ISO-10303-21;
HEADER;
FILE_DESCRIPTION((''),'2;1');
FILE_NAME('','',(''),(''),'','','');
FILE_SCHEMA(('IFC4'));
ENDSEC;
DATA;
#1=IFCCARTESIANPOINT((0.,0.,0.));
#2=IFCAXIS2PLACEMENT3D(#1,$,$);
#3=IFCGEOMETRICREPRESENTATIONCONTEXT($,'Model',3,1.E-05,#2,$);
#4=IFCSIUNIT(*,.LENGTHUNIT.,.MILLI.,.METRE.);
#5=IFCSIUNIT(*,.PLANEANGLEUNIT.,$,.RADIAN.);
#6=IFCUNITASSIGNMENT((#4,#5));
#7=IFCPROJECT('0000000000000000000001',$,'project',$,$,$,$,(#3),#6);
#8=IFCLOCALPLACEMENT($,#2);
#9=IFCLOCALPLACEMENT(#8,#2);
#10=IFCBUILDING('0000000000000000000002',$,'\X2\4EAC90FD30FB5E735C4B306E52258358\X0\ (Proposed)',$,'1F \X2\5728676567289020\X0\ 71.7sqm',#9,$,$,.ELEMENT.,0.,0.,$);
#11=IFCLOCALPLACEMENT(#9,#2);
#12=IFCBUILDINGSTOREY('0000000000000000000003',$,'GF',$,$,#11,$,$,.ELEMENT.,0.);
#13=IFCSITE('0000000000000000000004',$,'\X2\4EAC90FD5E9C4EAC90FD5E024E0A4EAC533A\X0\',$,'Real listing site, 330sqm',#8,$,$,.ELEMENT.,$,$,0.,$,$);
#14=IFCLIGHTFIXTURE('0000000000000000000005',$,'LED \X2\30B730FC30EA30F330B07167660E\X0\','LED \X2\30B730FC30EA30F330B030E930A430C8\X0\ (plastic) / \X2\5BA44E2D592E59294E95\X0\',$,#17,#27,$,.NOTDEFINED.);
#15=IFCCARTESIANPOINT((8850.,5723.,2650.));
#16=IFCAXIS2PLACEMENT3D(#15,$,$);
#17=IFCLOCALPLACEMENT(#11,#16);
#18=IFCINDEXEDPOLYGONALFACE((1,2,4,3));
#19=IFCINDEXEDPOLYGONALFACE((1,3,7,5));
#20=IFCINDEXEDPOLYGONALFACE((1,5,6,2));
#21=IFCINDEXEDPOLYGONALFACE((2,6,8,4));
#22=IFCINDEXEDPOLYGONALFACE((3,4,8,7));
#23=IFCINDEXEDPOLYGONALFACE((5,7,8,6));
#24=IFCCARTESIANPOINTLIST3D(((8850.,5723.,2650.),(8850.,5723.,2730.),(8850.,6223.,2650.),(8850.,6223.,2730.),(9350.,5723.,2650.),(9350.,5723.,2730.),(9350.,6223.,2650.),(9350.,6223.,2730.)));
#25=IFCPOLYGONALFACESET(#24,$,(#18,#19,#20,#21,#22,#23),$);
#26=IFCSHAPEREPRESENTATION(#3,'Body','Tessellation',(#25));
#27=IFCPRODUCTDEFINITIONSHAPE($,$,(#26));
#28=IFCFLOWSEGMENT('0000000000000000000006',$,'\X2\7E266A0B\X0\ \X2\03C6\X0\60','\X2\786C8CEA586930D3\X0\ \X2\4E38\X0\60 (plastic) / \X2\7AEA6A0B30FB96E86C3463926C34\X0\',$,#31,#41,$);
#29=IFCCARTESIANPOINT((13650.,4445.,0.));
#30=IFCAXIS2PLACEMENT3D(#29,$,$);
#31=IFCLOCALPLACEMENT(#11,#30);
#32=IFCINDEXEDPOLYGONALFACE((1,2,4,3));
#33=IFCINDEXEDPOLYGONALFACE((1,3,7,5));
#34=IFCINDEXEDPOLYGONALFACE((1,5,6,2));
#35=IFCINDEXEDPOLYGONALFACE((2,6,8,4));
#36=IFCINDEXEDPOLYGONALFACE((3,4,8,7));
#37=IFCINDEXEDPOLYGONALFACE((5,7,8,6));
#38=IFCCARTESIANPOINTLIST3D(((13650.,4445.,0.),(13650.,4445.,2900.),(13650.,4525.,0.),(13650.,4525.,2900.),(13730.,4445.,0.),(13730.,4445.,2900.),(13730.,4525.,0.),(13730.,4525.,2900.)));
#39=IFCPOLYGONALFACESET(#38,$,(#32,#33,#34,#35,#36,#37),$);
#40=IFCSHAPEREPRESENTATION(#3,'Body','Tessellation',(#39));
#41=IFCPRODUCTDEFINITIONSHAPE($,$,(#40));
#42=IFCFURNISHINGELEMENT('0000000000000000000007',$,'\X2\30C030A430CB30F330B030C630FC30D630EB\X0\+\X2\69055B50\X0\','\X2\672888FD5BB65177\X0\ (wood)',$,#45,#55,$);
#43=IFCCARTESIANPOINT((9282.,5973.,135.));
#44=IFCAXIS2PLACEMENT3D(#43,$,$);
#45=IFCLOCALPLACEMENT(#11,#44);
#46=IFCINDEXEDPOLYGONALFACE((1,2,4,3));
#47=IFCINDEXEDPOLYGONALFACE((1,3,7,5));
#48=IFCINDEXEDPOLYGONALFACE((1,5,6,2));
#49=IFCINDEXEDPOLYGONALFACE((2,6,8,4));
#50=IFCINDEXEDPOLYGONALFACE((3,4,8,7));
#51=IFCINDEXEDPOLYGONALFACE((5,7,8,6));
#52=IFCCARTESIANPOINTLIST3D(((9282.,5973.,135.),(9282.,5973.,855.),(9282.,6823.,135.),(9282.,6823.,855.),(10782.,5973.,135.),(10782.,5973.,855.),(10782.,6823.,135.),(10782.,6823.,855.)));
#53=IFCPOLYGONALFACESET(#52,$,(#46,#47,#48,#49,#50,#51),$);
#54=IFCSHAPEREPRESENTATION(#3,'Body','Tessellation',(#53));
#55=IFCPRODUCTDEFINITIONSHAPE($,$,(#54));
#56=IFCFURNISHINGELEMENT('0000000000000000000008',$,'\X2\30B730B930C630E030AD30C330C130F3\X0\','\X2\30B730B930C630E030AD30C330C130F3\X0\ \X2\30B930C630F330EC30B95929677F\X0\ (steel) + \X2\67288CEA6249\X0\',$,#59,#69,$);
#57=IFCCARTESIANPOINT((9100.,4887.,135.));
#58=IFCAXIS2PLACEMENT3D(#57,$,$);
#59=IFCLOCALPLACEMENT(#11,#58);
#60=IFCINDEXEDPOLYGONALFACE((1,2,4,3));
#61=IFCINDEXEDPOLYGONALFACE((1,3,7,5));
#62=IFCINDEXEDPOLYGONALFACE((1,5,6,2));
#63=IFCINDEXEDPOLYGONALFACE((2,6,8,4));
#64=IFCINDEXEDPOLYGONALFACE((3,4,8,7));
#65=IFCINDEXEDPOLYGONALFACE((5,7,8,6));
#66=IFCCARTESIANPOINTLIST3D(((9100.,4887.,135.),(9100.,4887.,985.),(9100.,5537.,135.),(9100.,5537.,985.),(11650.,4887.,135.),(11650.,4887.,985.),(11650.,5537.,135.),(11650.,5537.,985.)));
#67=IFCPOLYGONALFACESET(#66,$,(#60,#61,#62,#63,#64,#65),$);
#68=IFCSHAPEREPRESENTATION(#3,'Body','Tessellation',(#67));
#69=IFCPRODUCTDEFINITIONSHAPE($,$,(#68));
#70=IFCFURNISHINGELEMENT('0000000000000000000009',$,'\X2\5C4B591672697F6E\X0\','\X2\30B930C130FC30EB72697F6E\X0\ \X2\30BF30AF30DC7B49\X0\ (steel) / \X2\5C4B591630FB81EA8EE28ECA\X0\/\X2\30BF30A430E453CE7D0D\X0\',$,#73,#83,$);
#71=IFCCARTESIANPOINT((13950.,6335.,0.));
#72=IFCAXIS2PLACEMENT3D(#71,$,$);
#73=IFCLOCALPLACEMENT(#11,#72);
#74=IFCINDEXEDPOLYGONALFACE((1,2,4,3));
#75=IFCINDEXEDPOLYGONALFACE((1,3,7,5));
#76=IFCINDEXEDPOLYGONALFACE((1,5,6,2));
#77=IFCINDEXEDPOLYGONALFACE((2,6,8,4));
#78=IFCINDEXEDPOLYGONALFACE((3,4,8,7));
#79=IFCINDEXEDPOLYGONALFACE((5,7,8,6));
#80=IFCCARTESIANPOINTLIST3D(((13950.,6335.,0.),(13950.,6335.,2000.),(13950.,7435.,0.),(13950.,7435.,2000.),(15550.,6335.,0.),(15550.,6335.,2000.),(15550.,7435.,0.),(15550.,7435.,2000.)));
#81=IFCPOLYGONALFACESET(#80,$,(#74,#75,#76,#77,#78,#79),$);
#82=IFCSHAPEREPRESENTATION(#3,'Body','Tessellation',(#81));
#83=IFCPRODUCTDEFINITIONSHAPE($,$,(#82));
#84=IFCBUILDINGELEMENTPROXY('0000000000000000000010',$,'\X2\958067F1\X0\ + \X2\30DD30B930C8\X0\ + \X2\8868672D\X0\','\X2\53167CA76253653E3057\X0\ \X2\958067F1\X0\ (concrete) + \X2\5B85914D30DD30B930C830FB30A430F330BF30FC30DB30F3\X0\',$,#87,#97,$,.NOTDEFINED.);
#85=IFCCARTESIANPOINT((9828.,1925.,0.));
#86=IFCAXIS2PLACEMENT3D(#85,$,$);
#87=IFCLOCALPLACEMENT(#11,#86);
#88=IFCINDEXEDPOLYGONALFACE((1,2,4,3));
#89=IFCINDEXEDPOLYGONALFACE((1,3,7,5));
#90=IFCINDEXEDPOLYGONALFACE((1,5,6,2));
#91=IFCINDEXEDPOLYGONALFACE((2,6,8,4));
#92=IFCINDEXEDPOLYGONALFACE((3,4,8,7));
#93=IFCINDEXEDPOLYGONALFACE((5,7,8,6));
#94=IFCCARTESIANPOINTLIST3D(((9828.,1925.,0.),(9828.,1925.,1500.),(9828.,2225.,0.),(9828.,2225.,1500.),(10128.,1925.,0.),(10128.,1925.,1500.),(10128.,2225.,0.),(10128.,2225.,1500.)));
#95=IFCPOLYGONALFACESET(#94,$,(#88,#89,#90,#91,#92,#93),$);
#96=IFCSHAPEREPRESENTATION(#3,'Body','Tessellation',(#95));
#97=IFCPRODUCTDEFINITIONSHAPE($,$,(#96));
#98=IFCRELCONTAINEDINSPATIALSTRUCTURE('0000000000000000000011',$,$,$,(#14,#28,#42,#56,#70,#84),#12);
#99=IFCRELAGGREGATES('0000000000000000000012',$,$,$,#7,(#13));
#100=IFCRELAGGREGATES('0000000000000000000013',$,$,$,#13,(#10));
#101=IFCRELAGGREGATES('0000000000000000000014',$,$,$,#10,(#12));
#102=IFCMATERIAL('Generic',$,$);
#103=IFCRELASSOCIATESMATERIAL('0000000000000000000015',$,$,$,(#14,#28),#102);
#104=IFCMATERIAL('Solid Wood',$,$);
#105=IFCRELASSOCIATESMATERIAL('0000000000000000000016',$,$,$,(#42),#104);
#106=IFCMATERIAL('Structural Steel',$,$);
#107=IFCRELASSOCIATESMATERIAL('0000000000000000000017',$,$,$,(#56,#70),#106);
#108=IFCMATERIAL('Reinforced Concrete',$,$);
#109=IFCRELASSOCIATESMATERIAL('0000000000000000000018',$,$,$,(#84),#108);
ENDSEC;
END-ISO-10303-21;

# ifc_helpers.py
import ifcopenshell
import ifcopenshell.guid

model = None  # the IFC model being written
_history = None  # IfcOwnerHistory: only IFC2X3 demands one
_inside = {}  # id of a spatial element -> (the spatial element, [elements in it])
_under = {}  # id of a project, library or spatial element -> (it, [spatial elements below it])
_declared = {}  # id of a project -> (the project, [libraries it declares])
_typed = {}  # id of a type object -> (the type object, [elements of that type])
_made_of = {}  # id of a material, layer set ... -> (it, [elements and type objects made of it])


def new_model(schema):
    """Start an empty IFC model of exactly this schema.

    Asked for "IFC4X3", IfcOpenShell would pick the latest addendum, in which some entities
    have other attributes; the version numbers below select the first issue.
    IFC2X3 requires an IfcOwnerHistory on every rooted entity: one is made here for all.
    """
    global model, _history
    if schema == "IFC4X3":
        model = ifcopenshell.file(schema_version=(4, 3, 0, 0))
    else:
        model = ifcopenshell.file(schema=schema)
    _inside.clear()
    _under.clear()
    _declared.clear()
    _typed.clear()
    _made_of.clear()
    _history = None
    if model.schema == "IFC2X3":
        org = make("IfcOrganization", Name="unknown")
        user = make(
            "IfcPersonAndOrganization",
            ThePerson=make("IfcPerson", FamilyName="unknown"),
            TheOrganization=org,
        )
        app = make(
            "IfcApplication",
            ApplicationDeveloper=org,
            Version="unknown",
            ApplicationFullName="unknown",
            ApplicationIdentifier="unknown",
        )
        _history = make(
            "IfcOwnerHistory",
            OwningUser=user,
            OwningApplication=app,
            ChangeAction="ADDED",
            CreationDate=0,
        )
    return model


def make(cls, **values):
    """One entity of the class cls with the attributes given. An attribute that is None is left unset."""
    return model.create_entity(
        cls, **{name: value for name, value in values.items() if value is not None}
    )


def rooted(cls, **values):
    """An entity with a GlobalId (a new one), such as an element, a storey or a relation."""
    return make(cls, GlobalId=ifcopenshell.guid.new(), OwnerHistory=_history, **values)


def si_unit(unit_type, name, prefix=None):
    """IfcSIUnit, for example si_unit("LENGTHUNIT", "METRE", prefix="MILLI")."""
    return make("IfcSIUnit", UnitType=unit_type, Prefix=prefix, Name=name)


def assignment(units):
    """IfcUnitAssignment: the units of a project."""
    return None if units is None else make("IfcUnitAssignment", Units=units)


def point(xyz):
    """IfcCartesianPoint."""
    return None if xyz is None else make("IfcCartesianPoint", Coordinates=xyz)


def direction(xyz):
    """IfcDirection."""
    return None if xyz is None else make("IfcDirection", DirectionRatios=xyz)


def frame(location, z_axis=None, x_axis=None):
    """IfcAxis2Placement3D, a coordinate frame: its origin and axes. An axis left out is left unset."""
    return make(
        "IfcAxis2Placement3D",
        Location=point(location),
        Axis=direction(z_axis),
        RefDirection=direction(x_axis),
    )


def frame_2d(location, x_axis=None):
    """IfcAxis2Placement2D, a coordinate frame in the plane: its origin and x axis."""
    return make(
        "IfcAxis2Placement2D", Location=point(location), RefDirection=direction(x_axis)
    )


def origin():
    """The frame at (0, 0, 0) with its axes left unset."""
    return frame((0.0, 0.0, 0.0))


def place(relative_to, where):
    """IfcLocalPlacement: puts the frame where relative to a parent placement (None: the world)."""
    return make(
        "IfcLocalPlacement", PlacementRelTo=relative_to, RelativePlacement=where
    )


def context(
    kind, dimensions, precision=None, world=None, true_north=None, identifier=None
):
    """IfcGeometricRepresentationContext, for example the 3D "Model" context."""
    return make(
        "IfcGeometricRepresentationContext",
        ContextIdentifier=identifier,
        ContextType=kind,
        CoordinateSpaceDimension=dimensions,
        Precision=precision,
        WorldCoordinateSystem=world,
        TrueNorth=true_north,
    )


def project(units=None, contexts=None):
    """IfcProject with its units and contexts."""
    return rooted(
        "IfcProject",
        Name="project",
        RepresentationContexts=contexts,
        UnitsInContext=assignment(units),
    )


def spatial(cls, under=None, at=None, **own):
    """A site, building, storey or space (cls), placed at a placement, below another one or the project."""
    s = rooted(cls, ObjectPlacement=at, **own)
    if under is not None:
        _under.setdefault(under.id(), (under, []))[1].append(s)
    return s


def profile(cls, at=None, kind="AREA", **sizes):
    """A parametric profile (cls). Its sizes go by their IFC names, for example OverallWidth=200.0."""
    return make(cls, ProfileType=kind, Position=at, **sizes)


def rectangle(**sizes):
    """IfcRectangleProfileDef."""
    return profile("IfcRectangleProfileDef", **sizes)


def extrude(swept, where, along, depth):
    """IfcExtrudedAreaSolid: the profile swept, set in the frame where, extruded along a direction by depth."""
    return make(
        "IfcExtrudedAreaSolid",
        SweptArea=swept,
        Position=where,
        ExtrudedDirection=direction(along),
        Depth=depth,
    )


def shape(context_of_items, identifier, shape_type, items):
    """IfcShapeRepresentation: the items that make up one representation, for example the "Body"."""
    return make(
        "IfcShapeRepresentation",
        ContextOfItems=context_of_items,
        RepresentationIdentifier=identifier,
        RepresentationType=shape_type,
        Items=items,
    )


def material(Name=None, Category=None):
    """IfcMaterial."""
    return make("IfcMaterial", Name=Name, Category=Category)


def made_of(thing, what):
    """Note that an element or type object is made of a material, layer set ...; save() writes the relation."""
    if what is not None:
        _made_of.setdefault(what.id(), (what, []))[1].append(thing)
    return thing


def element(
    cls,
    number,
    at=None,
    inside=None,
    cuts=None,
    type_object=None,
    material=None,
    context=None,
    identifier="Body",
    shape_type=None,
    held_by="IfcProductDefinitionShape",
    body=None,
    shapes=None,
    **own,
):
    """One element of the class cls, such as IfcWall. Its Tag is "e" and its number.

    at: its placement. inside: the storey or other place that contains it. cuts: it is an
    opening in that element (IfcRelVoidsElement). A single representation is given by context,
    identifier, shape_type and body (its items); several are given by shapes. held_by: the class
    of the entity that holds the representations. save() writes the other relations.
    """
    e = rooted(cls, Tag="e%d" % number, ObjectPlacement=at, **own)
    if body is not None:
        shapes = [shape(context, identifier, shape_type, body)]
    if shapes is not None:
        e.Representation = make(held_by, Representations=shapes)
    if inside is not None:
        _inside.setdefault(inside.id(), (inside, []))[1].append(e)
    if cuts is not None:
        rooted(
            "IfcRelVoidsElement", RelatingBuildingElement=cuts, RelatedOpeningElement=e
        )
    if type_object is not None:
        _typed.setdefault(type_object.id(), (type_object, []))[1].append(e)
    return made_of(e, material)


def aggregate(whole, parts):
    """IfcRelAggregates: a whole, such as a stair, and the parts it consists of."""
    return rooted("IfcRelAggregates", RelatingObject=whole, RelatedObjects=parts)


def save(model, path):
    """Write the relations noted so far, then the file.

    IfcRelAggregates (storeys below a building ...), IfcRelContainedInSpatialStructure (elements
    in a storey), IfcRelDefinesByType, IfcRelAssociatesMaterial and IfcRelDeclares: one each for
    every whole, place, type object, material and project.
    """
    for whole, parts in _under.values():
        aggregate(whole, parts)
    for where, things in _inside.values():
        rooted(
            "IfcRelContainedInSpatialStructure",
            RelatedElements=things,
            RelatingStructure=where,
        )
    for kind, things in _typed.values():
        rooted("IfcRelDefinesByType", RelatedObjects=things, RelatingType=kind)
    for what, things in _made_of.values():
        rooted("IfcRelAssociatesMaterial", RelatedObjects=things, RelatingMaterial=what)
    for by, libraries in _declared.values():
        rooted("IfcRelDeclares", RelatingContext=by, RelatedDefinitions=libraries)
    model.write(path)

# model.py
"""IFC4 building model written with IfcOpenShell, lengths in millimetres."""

from ifc_helpers import new_model, si_unit, frame, frame_2d, origin, place, context, project, spatial, rectangle, extrude, material, element, save


model = new_model("IFC4")

# Units and contexts
model_context = context("Model", 3, precision=1e-05, world=origin())
ifc_project = project(units=[si_unit("LENGTHUNIT", "METRE", prefix="MILLI"), si_unit("PLANEANGLEUNIT", "RADIAN")], contexts=[model_context])

# Site, building, storey
site_placement = place(None, origin())
site = spatial("IfcSite", under=ifc_project, at=site_placement, Name="京都府京都市上京区", ObjectType="Real listing site, 330sqm", CompositionType="ELEMENT", RefElevation=0.0)
building_placement = place(site_placement, origin())
building = spatial("IfcBuilding", under=site, at=building_placement, Name="京都・平屋の別荘 (Proposed)", ObjectType="1F 在来木造 71.7sqm", CompositionType="ELEMENT", ElevationOfRefHeight=0.0, ElevationOfTerrain=0.0)
storey_placement = place(building_placement, origin())
storey = spatial("IfcBuildingStorey", under=building, at=storey_placement, Name="GF", CompositionType="ELEMENT", Elevation=0.0)

# Shared definitions
ifc_material_1 = material(Name="Solid Wood")

# Shared definitions
ifc_material_2 = material(Name="Structural Steel")

# Shared definitions
ifc_material_3 = material(Name="Reinforced Concrete")

# Shared definitions
ifc_material_4 = material(Name="Generic")

# Light fixture
light_fixture_placement = place(storey_placement, frame((8850.0, 5723.0, 2650.0)))
element("IfcLightFixture", 1, at=light_fixture_placement, inside=storey, material=ifc_material_4, Name="LED シーリング照明", Description="LED シーリングライト (plastic) / 室中央天井", PredefinedType="NOTDEFINED", context=model_context, shape_type="SweptSolid", body=[
    extrude(rectangle(XDim=500.0, YDim=500.0, at=frame_2d((250.0, 250.0))), frame((8850.0, 5723.0, 2650.0)), (0.0, 0.0, 1.0), 80.0),
])

# Flow segment
flow_segment_placement = place(storey_placement, frame((13650.0, 4445.0, 0.0)))
element("IfcFlowSegment", 2, at=flow_segment_placement, inside=storey, material=ifc_material_4, Name="縦樋 φ60", Description="硬質塩ビ 丸60 (plastic) / 竪樋・雨水排水", context=model_context, shape_type="SweptSolid", body=[
    extrude(rectangle(XDim=80.0, YDim=80.0, at=frame_2d((40.0, 40.0))), frame((13650.0, 4445.0, 0.0)), (0.0, 0.0, 1.0), 2900.0),
])

# Furnishing elements
furnishing_1_placement = place(storey_placement, frame((9282.0, 5973.0, 135.0)))
element("IfcFurnishingElement", 3, at=furnishing_1_placement, inside=storey, material=ifc_material_1, Name="ダイニングテーブル+椅子", Description="木製家具 (wood)", context=model_context, shape_type="SweptSolid", body=[
    extrude(rectangle(XDim=1500.0, YDim=850.0, at=frame_2d((750.0, 425.0))), frame((9282.0, 5973.0, 135.0)), (0.0, 0.0, 1.0), 720.0),
])
furnishing_2_placement = place(storey_placement, frame((9100.0, 4887.0, 135.0)))
element("IfcFurnishingElement", 4, at=furnishing_2_placement, inside=storey, material=ifc_material_2, Name="システムキッチン", Description="システムキッチン ステンレス天板 (steel) + 木質扉", context=model_context, shape_type="SweptSolid", body=[
    extrude(rectangle(XDim=2550.0, YDim=650.0, at=frame_2d((1275.0, 325.0))), frame((9100.0, 4887.0, 135.0)), (0.0, 0.0, 1.0), 850.0),
])
furnishing_3_placement = place(storey_placement, frame((13950.0, 6335.0, 0.0)))
element("IfcFurnishingElement", 5, at=furnishing_3_placement, inside=storey, material=ifc_material_2, Name="屋外物置", Description="スチール物置 タクボ等 (steel) / 屋外・自転車/タイヤ収納", context=model_context, shape_type="SweptSolid", body=[
    extrude(rectangle(XDim=1600.0, YDim=1100.0, at=frame_2d((800.0, 550.0))), frame((13950.0, 6335.0, 0.0)), (0.0, 0.0, 1.0), 2000.0),
])

# Building element proxy
proxy_placement = place(storey_placement, frame((9828.0, 1925.0, 0.0)))
element("IfcBuildingElementProxy", 6, at=proxy_placement, inside=storey, material=ifc_material_3, Name="門柱 + ポスト + 表札", Description="化粧打放し 門柱 (concrete) + 宅配ポスト・インターホン", PredefinedType="NOTDEFINED", context=model_context, shape_type="SweptSolid", body=[
    extrude(rectangle(XDim=300.0, YDim=300.0, at=frame_2d((150.0, 150.0))), frame((9828.0, 1925.0, 0.0)), (0.0, 0.0, 1.0), 1500.0),
])

save(model, "model.ifc")
